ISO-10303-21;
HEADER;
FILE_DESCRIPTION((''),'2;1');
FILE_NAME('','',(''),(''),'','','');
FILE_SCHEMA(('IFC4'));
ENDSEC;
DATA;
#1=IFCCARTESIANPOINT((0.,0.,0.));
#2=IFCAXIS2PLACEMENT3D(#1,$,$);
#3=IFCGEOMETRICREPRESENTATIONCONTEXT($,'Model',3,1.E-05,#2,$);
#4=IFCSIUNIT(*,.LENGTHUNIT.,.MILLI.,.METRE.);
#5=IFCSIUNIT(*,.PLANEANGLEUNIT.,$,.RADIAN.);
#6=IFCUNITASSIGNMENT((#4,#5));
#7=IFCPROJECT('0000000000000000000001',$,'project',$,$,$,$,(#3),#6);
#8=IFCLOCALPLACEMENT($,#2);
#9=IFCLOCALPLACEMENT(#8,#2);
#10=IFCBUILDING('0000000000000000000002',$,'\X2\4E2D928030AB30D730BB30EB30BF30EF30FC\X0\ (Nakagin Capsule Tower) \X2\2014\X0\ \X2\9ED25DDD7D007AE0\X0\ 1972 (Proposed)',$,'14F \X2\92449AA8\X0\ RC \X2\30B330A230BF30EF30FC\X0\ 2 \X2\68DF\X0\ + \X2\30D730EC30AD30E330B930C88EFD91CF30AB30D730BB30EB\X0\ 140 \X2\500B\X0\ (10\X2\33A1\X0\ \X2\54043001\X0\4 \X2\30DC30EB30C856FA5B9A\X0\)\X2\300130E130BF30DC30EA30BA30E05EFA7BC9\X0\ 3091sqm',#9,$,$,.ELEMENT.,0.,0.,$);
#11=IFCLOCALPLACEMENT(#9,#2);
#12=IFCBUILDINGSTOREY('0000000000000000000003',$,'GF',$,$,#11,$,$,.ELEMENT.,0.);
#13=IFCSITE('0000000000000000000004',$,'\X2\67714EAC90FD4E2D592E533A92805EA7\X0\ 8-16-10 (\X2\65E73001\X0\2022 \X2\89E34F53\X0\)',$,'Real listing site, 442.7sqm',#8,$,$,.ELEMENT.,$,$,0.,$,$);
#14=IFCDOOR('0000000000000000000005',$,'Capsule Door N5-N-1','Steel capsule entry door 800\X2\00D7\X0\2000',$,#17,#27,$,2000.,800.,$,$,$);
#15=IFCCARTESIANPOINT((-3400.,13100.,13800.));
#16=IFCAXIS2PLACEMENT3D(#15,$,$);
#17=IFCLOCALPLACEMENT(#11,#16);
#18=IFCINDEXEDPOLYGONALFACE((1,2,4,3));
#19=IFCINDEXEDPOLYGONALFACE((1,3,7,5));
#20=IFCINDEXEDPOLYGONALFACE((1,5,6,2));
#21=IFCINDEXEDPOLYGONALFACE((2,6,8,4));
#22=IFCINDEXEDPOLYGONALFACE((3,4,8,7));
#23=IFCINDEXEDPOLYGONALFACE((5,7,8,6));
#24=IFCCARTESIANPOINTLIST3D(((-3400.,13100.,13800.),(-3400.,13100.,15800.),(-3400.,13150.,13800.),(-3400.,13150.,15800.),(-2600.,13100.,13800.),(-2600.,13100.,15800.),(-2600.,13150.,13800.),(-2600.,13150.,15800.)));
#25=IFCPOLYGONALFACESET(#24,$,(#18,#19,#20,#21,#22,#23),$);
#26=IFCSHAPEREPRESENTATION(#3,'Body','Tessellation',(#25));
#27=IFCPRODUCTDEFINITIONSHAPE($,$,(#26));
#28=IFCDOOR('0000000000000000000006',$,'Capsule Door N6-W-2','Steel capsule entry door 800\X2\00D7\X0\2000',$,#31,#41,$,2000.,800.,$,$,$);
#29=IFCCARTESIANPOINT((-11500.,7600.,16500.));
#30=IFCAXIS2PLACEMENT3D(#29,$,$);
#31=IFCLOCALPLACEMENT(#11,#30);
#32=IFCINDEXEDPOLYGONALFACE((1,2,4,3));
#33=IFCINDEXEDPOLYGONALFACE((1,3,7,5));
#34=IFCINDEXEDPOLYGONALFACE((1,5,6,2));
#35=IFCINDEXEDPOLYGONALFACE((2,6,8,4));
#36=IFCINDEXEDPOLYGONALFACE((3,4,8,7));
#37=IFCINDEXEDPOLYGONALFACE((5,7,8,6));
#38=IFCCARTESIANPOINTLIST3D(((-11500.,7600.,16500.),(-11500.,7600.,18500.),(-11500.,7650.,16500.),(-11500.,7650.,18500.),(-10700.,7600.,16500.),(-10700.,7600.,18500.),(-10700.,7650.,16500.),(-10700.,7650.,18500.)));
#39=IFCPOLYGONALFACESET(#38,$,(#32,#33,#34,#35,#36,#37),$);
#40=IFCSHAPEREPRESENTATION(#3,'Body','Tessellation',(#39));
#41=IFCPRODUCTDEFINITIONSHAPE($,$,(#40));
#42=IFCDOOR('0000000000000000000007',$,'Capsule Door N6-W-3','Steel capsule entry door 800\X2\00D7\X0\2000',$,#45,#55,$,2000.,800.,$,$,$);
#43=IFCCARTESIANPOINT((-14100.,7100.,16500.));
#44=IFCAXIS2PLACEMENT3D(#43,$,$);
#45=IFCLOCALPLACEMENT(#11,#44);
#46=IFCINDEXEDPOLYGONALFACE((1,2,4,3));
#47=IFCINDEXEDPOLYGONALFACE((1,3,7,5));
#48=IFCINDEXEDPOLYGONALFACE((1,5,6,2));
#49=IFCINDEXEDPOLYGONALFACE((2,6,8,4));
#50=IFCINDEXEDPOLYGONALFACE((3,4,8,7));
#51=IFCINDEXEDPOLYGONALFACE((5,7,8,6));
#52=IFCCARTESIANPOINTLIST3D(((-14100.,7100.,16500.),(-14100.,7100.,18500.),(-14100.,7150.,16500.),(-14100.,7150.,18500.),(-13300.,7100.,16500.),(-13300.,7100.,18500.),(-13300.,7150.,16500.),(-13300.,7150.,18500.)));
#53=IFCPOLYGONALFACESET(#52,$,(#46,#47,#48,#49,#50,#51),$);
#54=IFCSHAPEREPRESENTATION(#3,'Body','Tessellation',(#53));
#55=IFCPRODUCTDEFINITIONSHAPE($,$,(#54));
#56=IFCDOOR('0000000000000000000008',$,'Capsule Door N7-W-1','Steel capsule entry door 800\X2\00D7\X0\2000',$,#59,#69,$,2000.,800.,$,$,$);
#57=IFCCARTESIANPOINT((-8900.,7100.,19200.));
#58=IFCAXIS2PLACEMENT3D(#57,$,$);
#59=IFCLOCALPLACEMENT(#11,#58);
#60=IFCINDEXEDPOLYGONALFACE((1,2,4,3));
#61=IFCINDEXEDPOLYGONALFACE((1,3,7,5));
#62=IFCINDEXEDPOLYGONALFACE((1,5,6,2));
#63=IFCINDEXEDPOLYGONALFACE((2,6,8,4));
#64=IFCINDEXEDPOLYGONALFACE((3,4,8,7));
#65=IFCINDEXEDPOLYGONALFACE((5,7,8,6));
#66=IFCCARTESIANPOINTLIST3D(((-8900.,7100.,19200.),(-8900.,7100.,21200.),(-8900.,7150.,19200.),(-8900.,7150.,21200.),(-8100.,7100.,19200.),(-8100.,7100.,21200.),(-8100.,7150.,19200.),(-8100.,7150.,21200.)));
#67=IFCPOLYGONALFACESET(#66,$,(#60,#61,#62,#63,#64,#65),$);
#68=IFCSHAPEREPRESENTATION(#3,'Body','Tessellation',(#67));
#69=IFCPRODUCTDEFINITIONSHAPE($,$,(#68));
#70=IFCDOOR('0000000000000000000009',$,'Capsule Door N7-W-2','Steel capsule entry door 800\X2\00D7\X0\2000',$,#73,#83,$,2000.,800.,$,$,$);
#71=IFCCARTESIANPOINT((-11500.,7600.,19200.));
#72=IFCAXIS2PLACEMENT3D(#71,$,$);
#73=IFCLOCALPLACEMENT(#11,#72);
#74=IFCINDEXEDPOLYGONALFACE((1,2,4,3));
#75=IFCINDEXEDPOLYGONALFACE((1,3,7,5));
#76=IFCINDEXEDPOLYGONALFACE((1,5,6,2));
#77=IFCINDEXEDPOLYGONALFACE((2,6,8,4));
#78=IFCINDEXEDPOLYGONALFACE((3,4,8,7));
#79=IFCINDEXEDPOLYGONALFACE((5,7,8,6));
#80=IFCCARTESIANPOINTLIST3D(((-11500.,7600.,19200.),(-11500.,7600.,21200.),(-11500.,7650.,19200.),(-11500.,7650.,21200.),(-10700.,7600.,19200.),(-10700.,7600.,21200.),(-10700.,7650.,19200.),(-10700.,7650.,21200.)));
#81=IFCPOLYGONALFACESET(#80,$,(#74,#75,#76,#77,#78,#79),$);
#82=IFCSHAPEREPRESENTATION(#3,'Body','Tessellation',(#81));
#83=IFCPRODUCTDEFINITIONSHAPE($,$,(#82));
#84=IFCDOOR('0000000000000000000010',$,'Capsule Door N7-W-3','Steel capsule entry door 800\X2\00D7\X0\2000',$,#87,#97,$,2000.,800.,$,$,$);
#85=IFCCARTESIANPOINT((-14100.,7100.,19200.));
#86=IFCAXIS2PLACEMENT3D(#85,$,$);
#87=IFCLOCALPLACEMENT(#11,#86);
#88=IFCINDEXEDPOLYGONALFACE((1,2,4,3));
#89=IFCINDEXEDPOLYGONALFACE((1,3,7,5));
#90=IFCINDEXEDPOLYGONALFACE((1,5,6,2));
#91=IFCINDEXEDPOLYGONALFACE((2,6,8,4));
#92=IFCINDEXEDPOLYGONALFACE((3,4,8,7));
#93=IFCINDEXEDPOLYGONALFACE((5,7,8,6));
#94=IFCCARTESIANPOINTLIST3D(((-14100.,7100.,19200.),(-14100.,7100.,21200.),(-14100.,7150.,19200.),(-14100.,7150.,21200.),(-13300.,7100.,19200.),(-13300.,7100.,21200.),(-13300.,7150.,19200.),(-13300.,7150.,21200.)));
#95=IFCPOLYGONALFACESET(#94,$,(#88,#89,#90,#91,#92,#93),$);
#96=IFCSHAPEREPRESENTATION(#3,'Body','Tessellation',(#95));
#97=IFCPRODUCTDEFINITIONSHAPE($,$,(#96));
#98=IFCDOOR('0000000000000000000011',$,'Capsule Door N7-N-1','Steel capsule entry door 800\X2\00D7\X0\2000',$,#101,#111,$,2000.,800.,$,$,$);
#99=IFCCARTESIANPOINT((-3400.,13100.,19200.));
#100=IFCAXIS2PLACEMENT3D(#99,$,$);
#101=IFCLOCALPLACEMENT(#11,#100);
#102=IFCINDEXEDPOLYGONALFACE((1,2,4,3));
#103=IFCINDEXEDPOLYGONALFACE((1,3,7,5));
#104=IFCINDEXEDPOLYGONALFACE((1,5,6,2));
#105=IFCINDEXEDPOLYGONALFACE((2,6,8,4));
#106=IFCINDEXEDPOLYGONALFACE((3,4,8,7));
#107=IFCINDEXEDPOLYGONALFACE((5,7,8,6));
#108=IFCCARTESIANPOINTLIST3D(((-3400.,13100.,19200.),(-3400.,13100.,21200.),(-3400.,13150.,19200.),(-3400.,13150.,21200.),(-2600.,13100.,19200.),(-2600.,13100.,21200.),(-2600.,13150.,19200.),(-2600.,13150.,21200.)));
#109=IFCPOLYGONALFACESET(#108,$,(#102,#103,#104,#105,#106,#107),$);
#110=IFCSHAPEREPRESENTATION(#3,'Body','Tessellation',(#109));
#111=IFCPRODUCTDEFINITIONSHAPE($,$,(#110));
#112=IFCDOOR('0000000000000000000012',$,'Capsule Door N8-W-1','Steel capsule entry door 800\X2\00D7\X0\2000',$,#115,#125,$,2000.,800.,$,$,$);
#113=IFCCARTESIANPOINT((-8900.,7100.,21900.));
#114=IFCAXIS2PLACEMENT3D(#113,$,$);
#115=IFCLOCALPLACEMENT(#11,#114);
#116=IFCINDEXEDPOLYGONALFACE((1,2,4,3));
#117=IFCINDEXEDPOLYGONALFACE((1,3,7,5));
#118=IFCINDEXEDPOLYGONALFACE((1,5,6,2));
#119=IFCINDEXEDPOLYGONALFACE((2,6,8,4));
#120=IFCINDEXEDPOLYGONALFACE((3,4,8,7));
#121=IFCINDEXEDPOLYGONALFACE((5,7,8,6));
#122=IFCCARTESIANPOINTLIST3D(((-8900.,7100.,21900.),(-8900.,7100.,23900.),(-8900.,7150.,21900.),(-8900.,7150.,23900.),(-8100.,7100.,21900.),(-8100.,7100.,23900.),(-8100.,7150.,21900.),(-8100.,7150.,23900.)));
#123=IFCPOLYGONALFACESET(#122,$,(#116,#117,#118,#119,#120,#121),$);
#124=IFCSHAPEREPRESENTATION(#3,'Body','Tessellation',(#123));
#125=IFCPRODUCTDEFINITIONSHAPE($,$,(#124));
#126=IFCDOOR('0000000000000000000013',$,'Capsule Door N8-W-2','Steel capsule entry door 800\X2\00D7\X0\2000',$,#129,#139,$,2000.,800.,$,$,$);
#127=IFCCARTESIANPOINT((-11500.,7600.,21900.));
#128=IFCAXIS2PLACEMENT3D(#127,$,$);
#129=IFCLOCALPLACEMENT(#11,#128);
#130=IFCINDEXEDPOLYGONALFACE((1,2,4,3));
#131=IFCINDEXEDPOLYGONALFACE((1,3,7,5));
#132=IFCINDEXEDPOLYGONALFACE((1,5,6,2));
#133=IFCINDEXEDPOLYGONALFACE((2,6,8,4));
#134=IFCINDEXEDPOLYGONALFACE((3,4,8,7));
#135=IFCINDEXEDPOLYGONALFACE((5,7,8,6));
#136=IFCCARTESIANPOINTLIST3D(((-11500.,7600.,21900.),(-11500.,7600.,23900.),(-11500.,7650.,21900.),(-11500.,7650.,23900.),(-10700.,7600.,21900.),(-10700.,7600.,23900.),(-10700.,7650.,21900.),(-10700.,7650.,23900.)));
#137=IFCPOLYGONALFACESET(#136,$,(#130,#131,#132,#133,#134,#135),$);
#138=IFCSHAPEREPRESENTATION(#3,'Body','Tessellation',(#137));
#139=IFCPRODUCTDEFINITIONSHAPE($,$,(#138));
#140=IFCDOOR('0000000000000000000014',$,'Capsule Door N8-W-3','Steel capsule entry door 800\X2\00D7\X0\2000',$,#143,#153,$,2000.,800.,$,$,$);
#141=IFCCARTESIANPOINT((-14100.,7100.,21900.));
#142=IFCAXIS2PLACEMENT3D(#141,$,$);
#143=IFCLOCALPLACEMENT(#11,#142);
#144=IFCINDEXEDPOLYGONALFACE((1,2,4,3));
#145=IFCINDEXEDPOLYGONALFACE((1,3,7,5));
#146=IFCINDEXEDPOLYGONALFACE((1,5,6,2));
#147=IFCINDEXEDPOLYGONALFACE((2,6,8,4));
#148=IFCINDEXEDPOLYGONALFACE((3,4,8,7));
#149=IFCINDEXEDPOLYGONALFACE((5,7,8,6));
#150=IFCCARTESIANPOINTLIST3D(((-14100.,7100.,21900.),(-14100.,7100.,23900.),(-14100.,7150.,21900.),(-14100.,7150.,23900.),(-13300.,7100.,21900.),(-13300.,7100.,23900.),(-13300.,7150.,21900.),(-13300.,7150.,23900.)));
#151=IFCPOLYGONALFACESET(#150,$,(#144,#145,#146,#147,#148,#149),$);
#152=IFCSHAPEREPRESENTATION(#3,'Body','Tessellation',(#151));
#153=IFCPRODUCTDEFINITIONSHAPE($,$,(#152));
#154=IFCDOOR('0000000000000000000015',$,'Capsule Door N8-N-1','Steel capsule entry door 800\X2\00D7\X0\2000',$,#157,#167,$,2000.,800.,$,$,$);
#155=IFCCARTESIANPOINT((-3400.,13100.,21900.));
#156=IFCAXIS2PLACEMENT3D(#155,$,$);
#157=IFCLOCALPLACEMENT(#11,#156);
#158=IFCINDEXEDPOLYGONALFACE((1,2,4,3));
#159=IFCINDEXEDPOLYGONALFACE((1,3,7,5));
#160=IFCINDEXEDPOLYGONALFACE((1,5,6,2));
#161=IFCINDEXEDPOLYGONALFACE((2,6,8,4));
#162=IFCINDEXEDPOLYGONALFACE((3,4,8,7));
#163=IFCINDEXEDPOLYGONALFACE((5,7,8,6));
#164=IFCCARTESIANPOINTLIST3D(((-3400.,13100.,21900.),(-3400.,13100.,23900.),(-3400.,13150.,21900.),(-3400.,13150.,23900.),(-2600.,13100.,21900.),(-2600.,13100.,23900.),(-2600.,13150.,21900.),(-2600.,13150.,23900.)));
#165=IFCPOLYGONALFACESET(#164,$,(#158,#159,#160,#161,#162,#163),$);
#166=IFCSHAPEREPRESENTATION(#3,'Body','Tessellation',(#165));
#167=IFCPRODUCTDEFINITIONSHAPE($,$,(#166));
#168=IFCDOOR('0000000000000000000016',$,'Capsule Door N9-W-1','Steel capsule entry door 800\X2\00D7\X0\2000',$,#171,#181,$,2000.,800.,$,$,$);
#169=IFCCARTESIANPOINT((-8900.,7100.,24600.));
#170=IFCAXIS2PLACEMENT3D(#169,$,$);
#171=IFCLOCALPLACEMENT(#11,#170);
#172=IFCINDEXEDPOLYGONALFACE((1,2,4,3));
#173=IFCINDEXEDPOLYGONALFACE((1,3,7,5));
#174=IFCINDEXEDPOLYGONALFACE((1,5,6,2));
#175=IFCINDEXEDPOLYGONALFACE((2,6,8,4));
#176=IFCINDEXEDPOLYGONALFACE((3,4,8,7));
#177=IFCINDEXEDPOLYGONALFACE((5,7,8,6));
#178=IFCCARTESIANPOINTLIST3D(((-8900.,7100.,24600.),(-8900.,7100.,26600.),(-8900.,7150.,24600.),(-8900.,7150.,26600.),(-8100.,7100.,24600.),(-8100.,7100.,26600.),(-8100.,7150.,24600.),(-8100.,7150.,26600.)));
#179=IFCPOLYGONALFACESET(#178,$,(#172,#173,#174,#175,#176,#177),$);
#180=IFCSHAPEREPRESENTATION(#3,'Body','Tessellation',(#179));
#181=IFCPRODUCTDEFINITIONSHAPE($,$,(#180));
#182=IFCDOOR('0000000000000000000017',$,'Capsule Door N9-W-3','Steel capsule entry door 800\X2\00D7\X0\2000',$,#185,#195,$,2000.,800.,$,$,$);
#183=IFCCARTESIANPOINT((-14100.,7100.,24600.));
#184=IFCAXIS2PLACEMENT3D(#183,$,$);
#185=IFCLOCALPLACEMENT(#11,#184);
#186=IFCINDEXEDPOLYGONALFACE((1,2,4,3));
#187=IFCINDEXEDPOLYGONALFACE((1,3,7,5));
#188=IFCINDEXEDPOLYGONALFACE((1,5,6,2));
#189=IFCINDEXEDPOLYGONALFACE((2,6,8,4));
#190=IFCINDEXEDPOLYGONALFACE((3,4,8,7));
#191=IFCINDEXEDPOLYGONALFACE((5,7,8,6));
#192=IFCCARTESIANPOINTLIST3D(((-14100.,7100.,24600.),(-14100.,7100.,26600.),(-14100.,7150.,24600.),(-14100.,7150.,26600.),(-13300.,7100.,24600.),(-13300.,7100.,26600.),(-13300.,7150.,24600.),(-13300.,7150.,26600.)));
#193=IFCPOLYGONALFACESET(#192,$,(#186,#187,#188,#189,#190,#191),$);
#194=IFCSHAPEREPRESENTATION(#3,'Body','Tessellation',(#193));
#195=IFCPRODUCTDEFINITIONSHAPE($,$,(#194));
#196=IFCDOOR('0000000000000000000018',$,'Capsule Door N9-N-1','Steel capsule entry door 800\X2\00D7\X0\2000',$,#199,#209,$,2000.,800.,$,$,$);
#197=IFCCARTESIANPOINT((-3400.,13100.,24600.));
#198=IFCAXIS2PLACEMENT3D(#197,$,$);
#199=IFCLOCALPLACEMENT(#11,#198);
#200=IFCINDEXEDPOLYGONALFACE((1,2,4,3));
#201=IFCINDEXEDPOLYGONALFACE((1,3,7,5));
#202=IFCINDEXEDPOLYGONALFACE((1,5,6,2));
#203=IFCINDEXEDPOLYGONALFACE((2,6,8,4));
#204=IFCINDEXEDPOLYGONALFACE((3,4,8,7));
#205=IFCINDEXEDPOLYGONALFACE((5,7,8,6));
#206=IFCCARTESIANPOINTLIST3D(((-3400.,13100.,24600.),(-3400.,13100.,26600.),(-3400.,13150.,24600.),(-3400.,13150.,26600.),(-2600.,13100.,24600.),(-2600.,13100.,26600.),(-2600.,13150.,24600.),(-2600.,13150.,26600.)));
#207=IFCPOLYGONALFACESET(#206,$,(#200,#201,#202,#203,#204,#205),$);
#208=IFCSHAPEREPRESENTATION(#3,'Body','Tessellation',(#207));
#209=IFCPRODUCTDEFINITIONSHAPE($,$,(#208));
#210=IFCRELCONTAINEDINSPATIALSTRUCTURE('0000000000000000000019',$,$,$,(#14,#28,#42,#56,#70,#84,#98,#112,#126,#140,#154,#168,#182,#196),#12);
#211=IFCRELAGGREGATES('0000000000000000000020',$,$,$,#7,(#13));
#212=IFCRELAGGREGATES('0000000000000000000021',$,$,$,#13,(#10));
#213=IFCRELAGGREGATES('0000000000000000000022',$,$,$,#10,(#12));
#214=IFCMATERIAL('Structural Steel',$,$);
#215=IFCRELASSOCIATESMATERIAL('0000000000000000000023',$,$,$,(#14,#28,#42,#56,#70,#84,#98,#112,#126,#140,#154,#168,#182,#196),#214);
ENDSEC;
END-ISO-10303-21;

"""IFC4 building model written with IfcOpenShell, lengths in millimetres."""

from ifc_helpers import new_model, si_unit, frame, frame_2d, origin, place, context, project, spatial, rectangle, extrude, material, element, save


model = new_model("IFC4")

# Units and contexts
model_context = context("Model", 3, precision=1e-05, world=origin())
ifc_project = project(units=[si_unit("LENGTHUNIT", "METRE", prefix="MILLI"), si_unit("PLANEANGLEUNIT", "RADIAN")], contexts=[model_context])

# Site, building, storey
site_placement = place(None, origin())
site = spatial("IfcSite", under=ifc_project, at=site_placement, Name="東京都中央区銀座 8-16-10 (旧、2022 解体)", ObjectType="Real listing site, 442.7sqm", CompositionType="ELEMENT", RefElevation=0.0)
building_placement = place(site_placement, origin())
building = spatial("IfcBuilding", under=site, at=building_placement, Name="中銀カプセルタワー (Nakagin Capsule Tower) — 黒川紀章 1972 (Proposed)", ObjectType="14F 鉄骨 RC コアタワー 2 棟 + プレキャスト軽量カプセル 140 個 (10㎡ 各、4 ボルト固定)、メタボリズム建築 3091sqm", CompositionType="ELEMENT", ElevationOfRefHeight=0.0, ElevationOfTerrain=0.0)
storey_placement = place(building_placement, origin())
storey = spatial("IfcBuildingStorey", under=building, at=storey_placement, Name="GF", CompositionType="ELEMENT", Elevation=0.0)

# Doors
ifc_material_1 = material(Name="Structural Steel")
door_1_placement = place(storey_placement, frame((-3400.0, 13100.0, 13800.0)))
element("IfcDoor", 1, at=door_1_placement, inside=storey, material=ifc_material_1, Name="Capsule Door N5-N-1", Description="Steel capsule entry door 800×2000", OverallHeight=2000.0, OverallWidth=800.0, context=model_context, shape_type="SweptSolid", body=[
    extrude(rectangle(XDim=800.0, YDim=50.0, at=frame_2d((400.0, 25.0))), frame((-3400.0, 13100.0, 13800.0)), (0.0, 0.0, 1.0), 2000.0),
])
door_2_placement = place(storey_placement, frame((-11500.0, 7600.0, 16500.0)))
element("IfcDoor", 2, at=door_2_placement, inside=storey, material=ifc_material_1, Name="Capsule Door N6-W-2", Description="Steel capsule entry door 800×2000", OverallHeight=2000.0, OverallWidth=800.0, context=model_context, shape_type="SweptSolid", body=[
    extrude(rectangle(XDim=800.0, YDim=50.0, at=frame_2d((400.0, 25.0))), frame((-11500.0, 7600.0, 16500.0)), (0.0, 0.0, 1.0), 2000.0),
])
door_3_placement = place(storey_placement, frame((-14100.0, 7100.0, 16500.0)))
element("IfcDoor", 3, at=door_3_placement, inside=storey, material=ifc_material_1, Name="Capsule Door N6-W-3", Description="Steel capsule entry door 800×2000", OverallHeight=2000.0, OverallWidth=800.0, context=model_context, shape_type="SweptSolid", body=[
    extrude(rectangle(XDim=800.0, YDim=50.0, at=frame_2d((400.0, 25.0))), frame((-14100.0, 7100.0, 16500.0)), (0.0, 0.0, 1.0), 2000.0),
])
door_4_placement = place(storey_placement, frame((-8900.0, 7100.0, 19200.0)))
element("IfcDoor", 4, at=door_4_placement, inside=storey, material=ifc_material_1, Name="Capsule Door N7-W-1", Description="Steel capsule entry door 800×2000", OverallHeight=2000.0, OverallWidth=800.0, context=model_context, shape_type="SweptSolid", body=[
    extrude(rectangle(XDim=800.0, YDim=50.0, at=frame_2d((400.0, 25.0))), frame((-8900.0, 7100.0, 19200.0)), (0.0, 0.0, 1.0), 2000.0),
])
door_5_placement = place(storey_placement, frame((-11500.0, 7600.0, 19200.0)))
element("IfcDoor", 5, at=door_5_placement, inside=storey, material=ifc_material_1, Name="Capsule Door N7-W-2", Description="Steel capsule entry door 800×2000", OverallHeight=2000.0, OverallWidth=800.0, context=model_context, shape_type="SweptSolid", body=[
    extrude(rectangle(XDim=800.0, YDim=50.0, at=frame_2d((400.0, 25.0))), frame((-11500.0, 7600.0, 19200.0)), (0.0, 0.0, 1.0), 2000.0),
])
door_6_placement = place(storey_placement, frame((-14100.0, 7100.0, 19200.0)))
element("IfcDoor", 6, at=door_6_placement, inside=storey, material=ifc_material_1, Name="Capsule Door N7-W-3", Description="Steel capsule entry door 800×2000", OverallHeight=2000.0, OverallWidth=800.0, context=model_context, shape_type="SweptSolid", body=[
    extrude(rectangle(XDim=800.0, YDim=50.0, at=frame_2d((400.0, 25.0))), frame((-14100.0, 7100.0, 19200.0)), (0.0, 0.0, 1.0), 2000.0),
])
door_7_placement = place(storey_placement, frame((-3400.0, 13100.0, 19200.0)))
element("IfcDoor", 7, at=door_7_placement, inside=storey, material=ifc_material_1, Name="Capsule Door N7-N-1", Description="Steel capsule entry door 800×2000", OverallHeight=2000.0, OverallWidth=800.0, context=model_context, shape_type="SweptSolid", body=[
    extrude(rectangle(XDim=800.0, YDim=50.0, at=frame_2d((400.0, 25.0))), frame((-3400.0, 13100.0, 19200.0)), (0.0, 0.0, 1.0), 2000.0),
])
door_8_placement = place(storey_placement, frame((-8900.0, 7100.0, 21900.0)))
element("IfcDoor", 8, at=door_8_placement, inside=storey, material=ifc_material_1, Name="Capsule Door N8-W-1", Description="Steel capsule entry door 800×2000", OverallHeight=2000.0, OverallWidth=800.0, context=model_context, shape_type="SweptSolid", body=[
    extrude(rectangle(XDim=800.0, YDim=50.0, at=frame_2d((400.0, 25.0))), frame((-8900.0, 7100.0, 21900.0)), (0.0, 0.0, 1.0), 2000.0),
])
door_9_placement = place(storey_placement, frame((-11500.0, 7600.0, 21900.0)))
element("IfcDoor", 9, at=door_9_placement, inside=storey, material=ifc_material_1, Name="Capsule Door N8-W-2", Description="Steel capsule entry door 800×2000", OverallHeight=2000.0, OverallWidth=800.0, context=model_context, shape_type="SweptSolid", body=[
    extrude(rectangle(XDim=800.0, YDim=50.0, at=frame_2d((400.0, 25.0))), frame((-11500.0, 7600.0, 21900.0)), (0.0, 0.0, 1.0), 2000.0),
])
door_10_placement = place(storey_placement, frame((-14100.0, 7100.0, 21900.0)))
element("IfcDoor", 10, at=door_10_placement, inside=storey, material=ifc_material_1, Name="Capsule Door N8-W-3", Description="Steel capsule entry door 800×2000", OverallHeight=2000.0, OverallWidth=800.0, context=model_context, shape_type="SweptSolid", body=[
    extrude(rectangle(XDim=800.0, YDim=50.0, at=frame_2d((400.0, 25.0))), frame((-14100.0, 7100.0, 21900.0)), (0.0, 0.0, 1.0), 2000.0),
])
door_11_placement = place(storey_placement, frame((-3400.0, 13100.0, 21900.0)))
element("IfcDoor", 11, at=door_11_placement, inside=storey, material=ifc_material_1, Name="Capsule Door N8-N-1", Description="Steel capsule entry door 800×2000", OverallHeight=2000.0, OverallWidth=800.0, context=model_context, shape_type="SweptSolid", body=[
    extrude(rectangle(XDim=800.0, YDim=50.0, at=frame_2d((400.0, 25.0))), frame((-3400.0, 13100.0, 21900.0)), (0.0, 0.0, 1.0), 2000.0),
])
door_12_placement = place(storey_placement, frame((-8900.0, 7100.0, 24600.0)))
element("IfcDoor", 12, at=door_12_placement, inside=storey, material=ifc_material_1, Name="Capsule Door N9-W-1", Description="Steel capsule entry door 800×2000", OverallHeight=2000.0, OverallWidth=800.0, context=model_context, shape_type="SweptSolid", body=[
    extrude(rectangle(XDim=800.0, YDim=50.0, at=frame_2d((400.0, 25.0))), frame((-8900.0, 7100.0, 24600.0)), (0.0, 0.0, 1.0), 2000.0),
])
door_13_placement = place(storey_placement, frame((-14100.0, 7100.0, 24600.0)))
element("IfcDoor", 13, at=door_13_placement, inside=storey, material=ifc_material_1, Name="Capsule Door N9-W-3", Description="Steel capsule entry door 800×2000", OverallHeight=2000.0, OverallWidth=800.0, context=model_context, shape_type="SweptSolid", body=[
    extrude(rectangle(XDim=800.0, YDim=50.0, at=frame_2d((400.0, 25.0))), frame((-14100.0, 7100.0, 24600.0)), (0.0, 0.0, 1.0), 2000.0),
])
door_14_placement = place(storey_placement, frame((-3400.0, 13100.0, 24600.0)))
element("IfcDoor", 14, at=door_14_placement, inside=storey, material=ifc_material_1, Name="Capsule Door N9-N-1", Description="Steel capsule entry door 800×2000", OverallHeight=2000.0, OverallWidth=800.0, context=model_context, shape_type="SweptSolid", body=[
    extrude(rectangle(XDim=800.0, YDim=50.0, at=frame_2d((400.0, 25.0))), frame((-3400.0, 13100.0, 24600.0)), (0.0, 0.0, 1.0), 2000.0),
])

save(model, "model.ifc")
